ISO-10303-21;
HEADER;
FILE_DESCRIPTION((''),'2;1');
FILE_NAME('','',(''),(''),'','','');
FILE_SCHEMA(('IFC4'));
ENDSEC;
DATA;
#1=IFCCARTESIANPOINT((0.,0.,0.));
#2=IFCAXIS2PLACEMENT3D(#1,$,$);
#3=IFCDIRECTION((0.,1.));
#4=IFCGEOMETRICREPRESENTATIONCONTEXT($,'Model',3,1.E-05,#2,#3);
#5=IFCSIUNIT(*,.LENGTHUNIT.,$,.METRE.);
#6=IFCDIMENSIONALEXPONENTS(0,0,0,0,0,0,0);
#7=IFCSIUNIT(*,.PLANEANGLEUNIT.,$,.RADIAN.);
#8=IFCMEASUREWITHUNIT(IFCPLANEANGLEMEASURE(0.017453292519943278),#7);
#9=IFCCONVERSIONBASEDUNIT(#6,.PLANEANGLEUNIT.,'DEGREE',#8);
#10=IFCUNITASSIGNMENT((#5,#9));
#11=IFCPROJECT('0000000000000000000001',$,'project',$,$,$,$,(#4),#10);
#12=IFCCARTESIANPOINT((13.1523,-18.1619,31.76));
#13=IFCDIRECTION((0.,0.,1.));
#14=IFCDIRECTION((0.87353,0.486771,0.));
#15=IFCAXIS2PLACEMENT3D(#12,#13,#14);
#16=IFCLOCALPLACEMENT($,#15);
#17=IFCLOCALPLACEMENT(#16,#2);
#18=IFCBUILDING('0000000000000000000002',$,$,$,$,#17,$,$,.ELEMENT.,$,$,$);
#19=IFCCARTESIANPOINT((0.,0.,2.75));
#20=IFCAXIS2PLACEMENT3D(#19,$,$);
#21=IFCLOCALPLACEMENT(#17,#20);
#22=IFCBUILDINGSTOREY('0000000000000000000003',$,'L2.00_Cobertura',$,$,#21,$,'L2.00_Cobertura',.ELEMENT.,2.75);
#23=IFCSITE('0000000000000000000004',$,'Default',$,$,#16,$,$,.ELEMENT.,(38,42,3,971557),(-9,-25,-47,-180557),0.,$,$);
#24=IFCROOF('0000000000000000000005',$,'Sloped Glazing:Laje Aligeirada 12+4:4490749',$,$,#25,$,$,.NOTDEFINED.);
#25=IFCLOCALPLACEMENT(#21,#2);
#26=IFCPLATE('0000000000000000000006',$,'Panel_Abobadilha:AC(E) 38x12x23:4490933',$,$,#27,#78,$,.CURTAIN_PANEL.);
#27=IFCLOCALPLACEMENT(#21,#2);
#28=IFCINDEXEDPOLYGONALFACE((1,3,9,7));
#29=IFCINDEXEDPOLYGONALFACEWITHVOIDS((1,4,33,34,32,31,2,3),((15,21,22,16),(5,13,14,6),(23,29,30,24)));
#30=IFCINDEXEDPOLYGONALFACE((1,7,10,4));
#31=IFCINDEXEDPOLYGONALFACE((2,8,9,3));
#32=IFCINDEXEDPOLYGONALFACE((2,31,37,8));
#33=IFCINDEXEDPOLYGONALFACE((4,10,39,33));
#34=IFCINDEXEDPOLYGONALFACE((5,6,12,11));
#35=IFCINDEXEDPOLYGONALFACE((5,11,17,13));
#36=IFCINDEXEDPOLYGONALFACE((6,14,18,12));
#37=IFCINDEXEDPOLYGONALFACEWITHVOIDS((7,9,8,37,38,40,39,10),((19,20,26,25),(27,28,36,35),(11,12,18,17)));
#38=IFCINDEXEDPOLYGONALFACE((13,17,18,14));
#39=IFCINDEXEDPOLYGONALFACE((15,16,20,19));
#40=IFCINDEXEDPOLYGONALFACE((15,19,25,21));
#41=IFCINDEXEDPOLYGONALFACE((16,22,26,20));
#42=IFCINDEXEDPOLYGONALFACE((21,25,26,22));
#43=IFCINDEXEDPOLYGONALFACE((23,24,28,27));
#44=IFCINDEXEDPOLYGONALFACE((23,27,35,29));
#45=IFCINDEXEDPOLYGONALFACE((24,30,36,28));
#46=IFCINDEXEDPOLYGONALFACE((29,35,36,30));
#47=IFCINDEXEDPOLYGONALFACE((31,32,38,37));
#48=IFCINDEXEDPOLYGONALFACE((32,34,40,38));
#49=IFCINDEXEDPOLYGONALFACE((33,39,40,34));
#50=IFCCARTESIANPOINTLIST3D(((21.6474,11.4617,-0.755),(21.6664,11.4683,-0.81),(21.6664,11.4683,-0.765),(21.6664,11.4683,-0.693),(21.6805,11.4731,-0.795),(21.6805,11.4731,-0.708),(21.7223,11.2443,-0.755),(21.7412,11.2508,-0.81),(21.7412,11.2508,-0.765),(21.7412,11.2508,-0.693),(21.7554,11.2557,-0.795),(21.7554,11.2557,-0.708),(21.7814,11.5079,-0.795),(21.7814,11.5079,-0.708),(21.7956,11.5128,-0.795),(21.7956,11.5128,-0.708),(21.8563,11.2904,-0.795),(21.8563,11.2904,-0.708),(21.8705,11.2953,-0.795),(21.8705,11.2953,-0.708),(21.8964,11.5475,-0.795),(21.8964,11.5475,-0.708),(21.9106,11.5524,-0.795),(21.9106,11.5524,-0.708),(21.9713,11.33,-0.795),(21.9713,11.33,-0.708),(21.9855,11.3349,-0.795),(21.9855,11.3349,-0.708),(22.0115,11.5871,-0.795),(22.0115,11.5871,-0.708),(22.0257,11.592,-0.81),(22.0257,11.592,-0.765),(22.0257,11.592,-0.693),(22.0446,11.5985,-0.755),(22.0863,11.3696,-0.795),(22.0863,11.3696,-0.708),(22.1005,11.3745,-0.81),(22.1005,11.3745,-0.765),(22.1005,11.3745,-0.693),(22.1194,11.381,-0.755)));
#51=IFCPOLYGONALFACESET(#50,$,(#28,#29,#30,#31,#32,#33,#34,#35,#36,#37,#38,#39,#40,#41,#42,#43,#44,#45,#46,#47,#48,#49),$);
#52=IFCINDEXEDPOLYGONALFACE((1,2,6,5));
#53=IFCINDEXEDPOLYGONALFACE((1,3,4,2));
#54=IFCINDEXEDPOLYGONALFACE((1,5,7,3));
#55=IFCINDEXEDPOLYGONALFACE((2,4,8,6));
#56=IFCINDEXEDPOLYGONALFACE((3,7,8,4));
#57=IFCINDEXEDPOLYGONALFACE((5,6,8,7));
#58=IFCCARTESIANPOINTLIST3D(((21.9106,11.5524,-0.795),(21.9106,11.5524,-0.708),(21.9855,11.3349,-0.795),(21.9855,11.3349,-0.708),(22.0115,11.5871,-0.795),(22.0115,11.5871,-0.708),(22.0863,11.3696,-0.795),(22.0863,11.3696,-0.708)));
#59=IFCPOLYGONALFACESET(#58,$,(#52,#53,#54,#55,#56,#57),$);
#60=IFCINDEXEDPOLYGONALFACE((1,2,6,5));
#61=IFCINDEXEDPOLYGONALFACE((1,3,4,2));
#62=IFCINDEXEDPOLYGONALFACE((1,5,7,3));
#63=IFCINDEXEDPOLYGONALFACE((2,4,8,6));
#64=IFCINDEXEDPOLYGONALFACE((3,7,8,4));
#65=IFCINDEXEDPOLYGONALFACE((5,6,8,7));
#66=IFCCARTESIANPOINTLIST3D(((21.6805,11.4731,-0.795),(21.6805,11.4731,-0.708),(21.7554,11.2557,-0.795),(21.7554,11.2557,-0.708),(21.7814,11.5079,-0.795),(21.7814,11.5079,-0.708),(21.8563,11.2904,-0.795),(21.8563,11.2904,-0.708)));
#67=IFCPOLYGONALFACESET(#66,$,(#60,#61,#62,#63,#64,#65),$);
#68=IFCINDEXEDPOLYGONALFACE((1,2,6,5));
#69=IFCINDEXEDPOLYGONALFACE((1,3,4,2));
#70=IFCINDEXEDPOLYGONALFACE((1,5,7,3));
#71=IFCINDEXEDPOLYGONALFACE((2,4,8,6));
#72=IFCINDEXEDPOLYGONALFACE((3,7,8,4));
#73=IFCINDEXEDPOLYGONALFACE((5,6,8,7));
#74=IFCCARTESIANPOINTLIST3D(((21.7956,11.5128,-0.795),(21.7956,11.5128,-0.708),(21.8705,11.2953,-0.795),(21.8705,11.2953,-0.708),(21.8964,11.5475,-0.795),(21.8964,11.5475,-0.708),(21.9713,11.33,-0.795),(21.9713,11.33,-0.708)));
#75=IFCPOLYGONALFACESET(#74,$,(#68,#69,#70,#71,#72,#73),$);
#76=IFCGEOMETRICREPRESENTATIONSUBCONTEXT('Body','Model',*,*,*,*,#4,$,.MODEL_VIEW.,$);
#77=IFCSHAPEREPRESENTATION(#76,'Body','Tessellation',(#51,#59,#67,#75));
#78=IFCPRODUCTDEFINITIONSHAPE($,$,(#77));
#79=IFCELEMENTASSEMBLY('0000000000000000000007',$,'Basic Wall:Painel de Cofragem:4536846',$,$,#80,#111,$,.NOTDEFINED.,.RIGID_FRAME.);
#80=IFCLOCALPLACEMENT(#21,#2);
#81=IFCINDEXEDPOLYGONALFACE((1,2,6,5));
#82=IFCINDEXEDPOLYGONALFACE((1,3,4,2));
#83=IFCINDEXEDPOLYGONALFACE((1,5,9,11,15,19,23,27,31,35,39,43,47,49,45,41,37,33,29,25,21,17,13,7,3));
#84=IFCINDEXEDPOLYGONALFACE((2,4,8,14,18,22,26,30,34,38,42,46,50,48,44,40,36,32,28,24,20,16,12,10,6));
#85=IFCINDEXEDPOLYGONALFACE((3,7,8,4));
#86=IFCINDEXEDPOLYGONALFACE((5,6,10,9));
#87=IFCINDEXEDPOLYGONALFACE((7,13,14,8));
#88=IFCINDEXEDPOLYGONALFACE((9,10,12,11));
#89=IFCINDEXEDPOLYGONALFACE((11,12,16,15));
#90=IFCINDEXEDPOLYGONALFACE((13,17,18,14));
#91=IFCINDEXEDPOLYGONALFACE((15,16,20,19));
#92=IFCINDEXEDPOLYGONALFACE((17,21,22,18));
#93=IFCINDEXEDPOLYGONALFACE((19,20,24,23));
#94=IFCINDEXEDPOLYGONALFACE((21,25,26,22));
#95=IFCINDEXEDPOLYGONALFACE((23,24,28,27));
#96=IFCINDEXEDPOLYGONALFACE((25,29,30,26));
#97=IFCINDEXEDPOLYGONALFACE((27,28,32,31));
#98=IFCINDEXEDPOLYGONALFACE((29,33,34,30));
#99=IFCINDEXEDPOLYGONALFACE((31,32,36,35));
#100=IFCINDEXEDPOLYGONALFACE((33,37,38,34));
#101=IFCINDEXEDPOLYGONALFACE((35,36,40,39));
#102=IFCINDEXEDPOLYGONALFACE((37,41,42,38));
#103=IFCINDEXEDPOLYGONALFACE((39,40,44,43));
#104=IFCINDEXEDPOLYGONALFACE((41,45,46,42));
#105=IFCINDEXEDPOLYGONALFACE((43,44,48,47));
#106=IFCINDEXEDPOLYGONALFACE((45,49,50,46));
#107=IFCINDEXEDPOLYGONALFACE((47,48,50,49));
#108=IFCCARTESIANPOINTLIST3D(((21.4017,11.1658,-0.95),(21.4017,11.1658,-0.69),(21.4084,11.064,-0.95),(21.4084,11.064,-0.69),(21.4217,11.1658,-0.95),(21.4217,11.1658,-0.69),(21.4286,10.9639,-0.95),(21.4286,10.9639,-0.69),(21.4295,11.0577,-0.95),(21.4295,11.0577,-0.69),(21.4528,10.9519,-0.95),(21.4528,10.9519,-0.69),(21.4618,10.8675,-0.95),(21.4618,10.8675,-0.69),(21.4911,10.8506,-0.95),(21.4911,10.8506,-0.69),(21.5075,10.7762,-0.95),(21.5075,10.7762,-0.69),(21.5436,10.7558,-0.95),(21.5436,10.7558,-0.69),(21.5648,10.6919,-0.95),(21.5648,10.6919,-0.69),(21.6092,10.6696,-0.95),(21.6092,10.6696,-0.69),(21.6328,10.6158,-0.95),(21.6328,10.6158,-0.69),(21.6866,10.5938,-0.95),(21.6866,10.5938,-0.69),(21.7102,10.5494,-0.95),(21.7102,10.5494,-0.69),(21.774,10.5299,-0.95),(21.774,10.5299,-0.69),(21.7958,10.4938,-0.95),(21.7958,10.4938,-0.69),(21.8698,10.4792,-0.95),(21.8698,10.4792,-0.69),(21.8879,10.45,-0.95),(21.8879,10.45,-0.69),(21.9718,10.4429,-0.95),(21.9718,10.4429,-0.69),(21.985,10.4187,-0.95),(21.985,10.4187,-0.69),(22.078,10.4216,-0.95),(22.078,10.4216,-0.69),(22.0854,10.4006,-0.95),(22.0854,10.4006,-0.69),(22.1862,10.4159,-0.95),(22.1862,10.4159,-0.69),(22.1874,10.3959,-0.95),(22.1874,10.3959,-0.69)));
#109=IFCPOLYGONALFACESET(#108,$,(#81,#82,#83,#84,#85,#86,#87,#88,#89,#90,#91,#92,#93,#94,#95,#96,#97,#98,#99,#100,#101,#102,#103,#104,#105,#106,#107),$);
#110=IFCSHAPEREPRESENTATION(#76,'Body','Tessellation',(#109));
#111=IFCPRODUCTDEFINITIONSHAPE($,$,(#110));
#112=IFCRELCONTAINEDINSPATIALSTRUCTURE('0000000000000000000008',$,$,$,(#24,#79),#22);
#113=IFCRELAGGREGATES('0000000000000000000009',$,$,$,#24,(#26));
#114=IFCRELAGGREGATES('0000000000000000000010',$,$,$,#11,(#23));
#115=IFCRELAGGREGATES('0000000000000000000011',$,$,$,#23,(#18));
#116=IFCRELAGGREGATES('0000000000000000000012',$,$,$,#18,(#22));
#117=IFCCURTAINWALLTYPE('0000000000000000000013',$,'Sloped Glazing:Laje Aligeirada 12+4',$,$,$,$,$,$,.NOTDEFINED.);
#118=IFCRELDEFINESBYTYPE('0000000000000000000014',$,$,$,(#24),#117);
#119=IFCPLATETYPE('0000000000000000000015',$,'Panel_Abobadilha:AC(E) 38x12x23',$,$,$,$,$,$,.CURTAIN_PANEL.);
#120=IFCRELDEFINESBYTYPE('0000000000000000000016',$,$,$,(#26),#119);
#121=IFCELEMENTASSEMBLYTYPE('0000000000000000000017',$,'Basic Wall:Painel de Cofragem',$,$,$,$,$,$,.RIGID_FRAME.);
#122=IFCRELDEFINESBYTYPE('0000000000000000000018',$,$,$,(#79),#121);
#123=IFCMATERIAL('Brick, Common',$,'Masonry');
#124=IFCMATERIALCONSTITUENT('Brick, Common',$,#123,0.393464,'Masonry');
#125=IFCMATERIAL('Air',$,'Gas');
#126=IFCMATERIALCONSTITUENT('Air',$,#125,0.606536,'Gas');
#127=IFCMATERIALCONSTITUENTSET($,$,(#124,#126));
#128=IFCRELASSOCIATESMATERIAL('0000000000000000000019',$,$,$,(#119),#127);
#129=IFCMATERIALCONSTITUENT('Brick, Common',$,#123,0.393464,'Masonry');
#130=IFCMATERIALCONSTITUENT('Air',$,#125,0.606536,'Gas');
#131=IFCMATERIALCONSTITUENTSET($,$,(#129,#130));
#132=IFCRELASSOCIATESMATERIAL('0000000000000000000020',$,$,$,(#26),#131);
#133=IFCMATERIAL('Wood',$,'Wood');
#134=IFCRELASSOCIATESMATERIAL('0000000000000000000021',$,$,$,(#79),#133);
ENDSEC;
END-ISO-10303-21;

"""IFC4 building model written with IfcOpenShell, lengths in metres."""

from ifc_helpers import new_model, entity, si_unit, converted_unit, direction, frame, origin, place, context, subcontext, project, spatial, line, arc, indexed_curve, outline, extrude, source, transform, mapped, material, constituent, constituent_set, type_object, type_shapes, element, aggregate, save


model = new_model("IFC4")

# Units and contexts
model_context = context("Model", 3, precision=1e-05, world=origin(), true_north=direction((0.0, 1.0)))
body_context = subcontext(model_context, "Body", "Model", "MODEL_VIEW")
ifc_project = project(units=[si_unit("LENGTHUNIT", "METRE"), converted_unit("PLANEANGLEUNIT", "DEGREE", entity("IfcPlaneAngleMeasure", 0.017453292519943278), si_unit("PLANEANGLEUNIT", "RADIAN"), dimensions=[0, 0, 0, 0, 0, 0, 0])], contexts=[model_context])

# Site, building, storey
site_placement = place(None, frame((13.1523, -18.1619, 31.76), z_axis=(0.0, 0.0, 1.0), x_axis=(0.87353, 0.486771, 0.0)))
site = spatial("IfcSite", under=ifc_project, at=site_placement, Name="Default", CompositionType="ELEMENT", RefLatitude=(38, 42, 3, 971557), RefLongitude=(-9, -25, -47, -180557), RefElevation=0.0)
building_placement = place(site_placement, origin())
building = spatial("IfcBuilding", under=site, at=building_placement, CompositionType="ELEMENT")
storey_placement = place(building_placement, frame((0.0, 0.0, 2.75)))
storey = spatial("IfcBuildingStorey", under=building, at=storey_placement, Name="L2.00_Cobertura", LongName="L2.00_Cobertura", CompositionType="ELEMENT", Elevation=2.75)

# Roof
curtain_wall_type = type_object("IfcCurtainWallType", Name="Sloped Glazing:Laje Aligeirada 12+4", PredefinedType="NOTDEFINED")
roof_placement = place(storey_placement, frame((0.0, 0.0, -2.75)))
roof = element("IfcRoof", 1, at=roof_placement, inside=storey, type_object=curtain_wall_type, Name="Sloped Glazing:Laje Aligeirada 12+4:4490749", PredefinedType="NOTDEFINED")

# Shared definitions
ifc_material_1 = material(Name="Wood", Category="Wood")

# Plate
ifc_material_2 = material(Name="Brick, Common", Category="Masonry")
ifc_material_3 = material(Name="Air", Category="Gas")
ifc_constituent_1 = constituent(ifc_material_2, Name="Brick, Common", Category="Masonry", fraction=0.393464)
ifc_constituent_2 = constituent(ifc_material_3, Name="Air", Category="Gas", fraction=0.606536)
ifc_constituent_set_1 = constituent_set(constituents=[ifc_constituent_1, ifc_constituent_2])
plate_type_1 = type_object("IfcPlateType", Name="Panel_Abobadilha:AC(E) 38x12x23", PredefinedType="CURTAIN_PANEL", material=ifc_constituent_set_1)
shared_shape_1 = source(origin(), body_context, "Body", "SweptSolid", [
    extrude(outline(indexed_curve([(-0.19, -0.0543), (0.19, -0.0543), (0.19, -0.0093), (0.21, 0.0007), (0.19, 0.0628), (-0.19, 0.0628), (-0.21, 0.0007), (-0.19, -0.0093), (-0.19, -0.0543)], self_intersect=False), holes=[indexed_curve([(-0.0683, 0.0477), (-0.0683, -0.0393), (-0.175, -0.0393), (-0.175, 0.0477), (-0.0683, 0.0477)], self_intersect=False), indexed_curve([(0.0533, 0.0477), (0.0533, -0.0393), (-0.0533, -0.0393), (-0.0533, 0.0477), (0.0533, 0.0477)], self_intersect=False), indexed_curve([(0.175, 0.0477), (0.175, -0.0393), (0.0683, -0.0393), (0.0683, 0.0477), (0.175, 0.0477)], self_intersect=False)]), frame((0.0, 0.0543, 0.0)), (0.0, 0.0, 1.0), 0.23),
    extrude(outline(indexed_curve([(-0.0533, -0.0435), (0.0533, -0.0435), (0.0533, 0.0435), (-0.0533, 0.0435), (-0.0533, -0.0435)], self_intersect=False)), frame((0.1217, 0.0585, 0.0), z_axis=(0.0, 0.0, 1.0), x_axis=(-1.0, 0.0, 0.0)), (0.0, 0.0, 1.0), 0.23),
    extrude(outline(indexed_curve([(-0.0533, -0.0435), (0.0533, -0.0435), (0.0533, 0.0435), (-0.0533, 0.0435), (-0.0533, -0.0435)], self_intersect=False)), frame((-0.1217, 0.0585, 0.0), z_axis=(0.0, 0.0, 1.0), x_axis=(-1.0, 0.0, 0.0)), (0.0, 0.0, 1.0), 0.23),
    extrude(outline(indexed_curve([(-0.0533, -0.0435), (0.0533, -0.0435), (0.0533, 0.0435), (-0.0533, 0.0435), (-0.0533, -0.0435)], self_intersect=False)), frame((0.0, 0.0585, 0.0), z_axis=(0.0, 0.0, 1.0), x_axis=(-1.0, 0.0, 0.0)), (0.0, 0.0, 1.0), 0.23),
])
type_shapes(plate_type_1, [shared_shape_1])
ifc_constituent_3 = constituent(ifc_material_2, Name="Brick, Common", Category="Masonry", fraction=0.393464)
ifc_constituent_4 = constituent(ifc_material_3, Name="Air", Category="Gas", fraction=0.606536)
ifc_constituent_set_2 = constituent_set(constituents=[ifc_constituent_3, ifc_constituent_4])
plate_1_placement = place(roof_placement, frame((21.846, 11.5301, 1.94), z_axis=(0.325568, -0.945519, 0.0), x_axis=(0.945519, 0.325568, 0.0)))
plate_1 = element("IfcPlate", 2, at=plate_1_placement, type_object=plate_type_1, material=ifc_constituent_set_2, Name="Panel_Abobadilha:AC(E) 38x12x23:4490933", PredefinedType="CURTAIN_PANEL", context=body_context, shape_type="MappedRepresentation", body=[
    mapped(shared_shape_1, transform((0.0, 0.0, 0.0), scale=1.0)),
])
aggregate(roof, [plate_1])

# Element assembly
element_assembly_type = type_object("IfcElementAssemblyType", Name="Basic Wall:Painel de Cofragem", PredefinedType="RIGID_FRAME")
assembly_1_placement = place(storey_placement, frame((21.4117, 11.1658, -0.95)))
element("IfcElementAssembly", 3, at=assembly_1_placement, inside=storey, type_object=element_assembly_type, material=ifc_material_1, Name="Basic Wall:Painel de Cofragem:4536846", AssemblyPlace="NOTDEFINED", PredefinedType="RIGID_FRAME", context=body_context, shape_type="SweptSolid", body=[
    extrude(outline(indexed_curve([(0.7745, -0.7499), (0.2348, -0.5354), (0.01, 0.0), (-0.01, 0.0), (0.2211, -0.55), (0.7757, -0.7698)], segments=[arc(1, 2, 3), line(3, 4), arc(4, 5, 6), line(6, 1)], self_intersect=False)), origin(), (0.0, 0.0, 1.0), 0.26),
])

save(model, "model.ifc")
